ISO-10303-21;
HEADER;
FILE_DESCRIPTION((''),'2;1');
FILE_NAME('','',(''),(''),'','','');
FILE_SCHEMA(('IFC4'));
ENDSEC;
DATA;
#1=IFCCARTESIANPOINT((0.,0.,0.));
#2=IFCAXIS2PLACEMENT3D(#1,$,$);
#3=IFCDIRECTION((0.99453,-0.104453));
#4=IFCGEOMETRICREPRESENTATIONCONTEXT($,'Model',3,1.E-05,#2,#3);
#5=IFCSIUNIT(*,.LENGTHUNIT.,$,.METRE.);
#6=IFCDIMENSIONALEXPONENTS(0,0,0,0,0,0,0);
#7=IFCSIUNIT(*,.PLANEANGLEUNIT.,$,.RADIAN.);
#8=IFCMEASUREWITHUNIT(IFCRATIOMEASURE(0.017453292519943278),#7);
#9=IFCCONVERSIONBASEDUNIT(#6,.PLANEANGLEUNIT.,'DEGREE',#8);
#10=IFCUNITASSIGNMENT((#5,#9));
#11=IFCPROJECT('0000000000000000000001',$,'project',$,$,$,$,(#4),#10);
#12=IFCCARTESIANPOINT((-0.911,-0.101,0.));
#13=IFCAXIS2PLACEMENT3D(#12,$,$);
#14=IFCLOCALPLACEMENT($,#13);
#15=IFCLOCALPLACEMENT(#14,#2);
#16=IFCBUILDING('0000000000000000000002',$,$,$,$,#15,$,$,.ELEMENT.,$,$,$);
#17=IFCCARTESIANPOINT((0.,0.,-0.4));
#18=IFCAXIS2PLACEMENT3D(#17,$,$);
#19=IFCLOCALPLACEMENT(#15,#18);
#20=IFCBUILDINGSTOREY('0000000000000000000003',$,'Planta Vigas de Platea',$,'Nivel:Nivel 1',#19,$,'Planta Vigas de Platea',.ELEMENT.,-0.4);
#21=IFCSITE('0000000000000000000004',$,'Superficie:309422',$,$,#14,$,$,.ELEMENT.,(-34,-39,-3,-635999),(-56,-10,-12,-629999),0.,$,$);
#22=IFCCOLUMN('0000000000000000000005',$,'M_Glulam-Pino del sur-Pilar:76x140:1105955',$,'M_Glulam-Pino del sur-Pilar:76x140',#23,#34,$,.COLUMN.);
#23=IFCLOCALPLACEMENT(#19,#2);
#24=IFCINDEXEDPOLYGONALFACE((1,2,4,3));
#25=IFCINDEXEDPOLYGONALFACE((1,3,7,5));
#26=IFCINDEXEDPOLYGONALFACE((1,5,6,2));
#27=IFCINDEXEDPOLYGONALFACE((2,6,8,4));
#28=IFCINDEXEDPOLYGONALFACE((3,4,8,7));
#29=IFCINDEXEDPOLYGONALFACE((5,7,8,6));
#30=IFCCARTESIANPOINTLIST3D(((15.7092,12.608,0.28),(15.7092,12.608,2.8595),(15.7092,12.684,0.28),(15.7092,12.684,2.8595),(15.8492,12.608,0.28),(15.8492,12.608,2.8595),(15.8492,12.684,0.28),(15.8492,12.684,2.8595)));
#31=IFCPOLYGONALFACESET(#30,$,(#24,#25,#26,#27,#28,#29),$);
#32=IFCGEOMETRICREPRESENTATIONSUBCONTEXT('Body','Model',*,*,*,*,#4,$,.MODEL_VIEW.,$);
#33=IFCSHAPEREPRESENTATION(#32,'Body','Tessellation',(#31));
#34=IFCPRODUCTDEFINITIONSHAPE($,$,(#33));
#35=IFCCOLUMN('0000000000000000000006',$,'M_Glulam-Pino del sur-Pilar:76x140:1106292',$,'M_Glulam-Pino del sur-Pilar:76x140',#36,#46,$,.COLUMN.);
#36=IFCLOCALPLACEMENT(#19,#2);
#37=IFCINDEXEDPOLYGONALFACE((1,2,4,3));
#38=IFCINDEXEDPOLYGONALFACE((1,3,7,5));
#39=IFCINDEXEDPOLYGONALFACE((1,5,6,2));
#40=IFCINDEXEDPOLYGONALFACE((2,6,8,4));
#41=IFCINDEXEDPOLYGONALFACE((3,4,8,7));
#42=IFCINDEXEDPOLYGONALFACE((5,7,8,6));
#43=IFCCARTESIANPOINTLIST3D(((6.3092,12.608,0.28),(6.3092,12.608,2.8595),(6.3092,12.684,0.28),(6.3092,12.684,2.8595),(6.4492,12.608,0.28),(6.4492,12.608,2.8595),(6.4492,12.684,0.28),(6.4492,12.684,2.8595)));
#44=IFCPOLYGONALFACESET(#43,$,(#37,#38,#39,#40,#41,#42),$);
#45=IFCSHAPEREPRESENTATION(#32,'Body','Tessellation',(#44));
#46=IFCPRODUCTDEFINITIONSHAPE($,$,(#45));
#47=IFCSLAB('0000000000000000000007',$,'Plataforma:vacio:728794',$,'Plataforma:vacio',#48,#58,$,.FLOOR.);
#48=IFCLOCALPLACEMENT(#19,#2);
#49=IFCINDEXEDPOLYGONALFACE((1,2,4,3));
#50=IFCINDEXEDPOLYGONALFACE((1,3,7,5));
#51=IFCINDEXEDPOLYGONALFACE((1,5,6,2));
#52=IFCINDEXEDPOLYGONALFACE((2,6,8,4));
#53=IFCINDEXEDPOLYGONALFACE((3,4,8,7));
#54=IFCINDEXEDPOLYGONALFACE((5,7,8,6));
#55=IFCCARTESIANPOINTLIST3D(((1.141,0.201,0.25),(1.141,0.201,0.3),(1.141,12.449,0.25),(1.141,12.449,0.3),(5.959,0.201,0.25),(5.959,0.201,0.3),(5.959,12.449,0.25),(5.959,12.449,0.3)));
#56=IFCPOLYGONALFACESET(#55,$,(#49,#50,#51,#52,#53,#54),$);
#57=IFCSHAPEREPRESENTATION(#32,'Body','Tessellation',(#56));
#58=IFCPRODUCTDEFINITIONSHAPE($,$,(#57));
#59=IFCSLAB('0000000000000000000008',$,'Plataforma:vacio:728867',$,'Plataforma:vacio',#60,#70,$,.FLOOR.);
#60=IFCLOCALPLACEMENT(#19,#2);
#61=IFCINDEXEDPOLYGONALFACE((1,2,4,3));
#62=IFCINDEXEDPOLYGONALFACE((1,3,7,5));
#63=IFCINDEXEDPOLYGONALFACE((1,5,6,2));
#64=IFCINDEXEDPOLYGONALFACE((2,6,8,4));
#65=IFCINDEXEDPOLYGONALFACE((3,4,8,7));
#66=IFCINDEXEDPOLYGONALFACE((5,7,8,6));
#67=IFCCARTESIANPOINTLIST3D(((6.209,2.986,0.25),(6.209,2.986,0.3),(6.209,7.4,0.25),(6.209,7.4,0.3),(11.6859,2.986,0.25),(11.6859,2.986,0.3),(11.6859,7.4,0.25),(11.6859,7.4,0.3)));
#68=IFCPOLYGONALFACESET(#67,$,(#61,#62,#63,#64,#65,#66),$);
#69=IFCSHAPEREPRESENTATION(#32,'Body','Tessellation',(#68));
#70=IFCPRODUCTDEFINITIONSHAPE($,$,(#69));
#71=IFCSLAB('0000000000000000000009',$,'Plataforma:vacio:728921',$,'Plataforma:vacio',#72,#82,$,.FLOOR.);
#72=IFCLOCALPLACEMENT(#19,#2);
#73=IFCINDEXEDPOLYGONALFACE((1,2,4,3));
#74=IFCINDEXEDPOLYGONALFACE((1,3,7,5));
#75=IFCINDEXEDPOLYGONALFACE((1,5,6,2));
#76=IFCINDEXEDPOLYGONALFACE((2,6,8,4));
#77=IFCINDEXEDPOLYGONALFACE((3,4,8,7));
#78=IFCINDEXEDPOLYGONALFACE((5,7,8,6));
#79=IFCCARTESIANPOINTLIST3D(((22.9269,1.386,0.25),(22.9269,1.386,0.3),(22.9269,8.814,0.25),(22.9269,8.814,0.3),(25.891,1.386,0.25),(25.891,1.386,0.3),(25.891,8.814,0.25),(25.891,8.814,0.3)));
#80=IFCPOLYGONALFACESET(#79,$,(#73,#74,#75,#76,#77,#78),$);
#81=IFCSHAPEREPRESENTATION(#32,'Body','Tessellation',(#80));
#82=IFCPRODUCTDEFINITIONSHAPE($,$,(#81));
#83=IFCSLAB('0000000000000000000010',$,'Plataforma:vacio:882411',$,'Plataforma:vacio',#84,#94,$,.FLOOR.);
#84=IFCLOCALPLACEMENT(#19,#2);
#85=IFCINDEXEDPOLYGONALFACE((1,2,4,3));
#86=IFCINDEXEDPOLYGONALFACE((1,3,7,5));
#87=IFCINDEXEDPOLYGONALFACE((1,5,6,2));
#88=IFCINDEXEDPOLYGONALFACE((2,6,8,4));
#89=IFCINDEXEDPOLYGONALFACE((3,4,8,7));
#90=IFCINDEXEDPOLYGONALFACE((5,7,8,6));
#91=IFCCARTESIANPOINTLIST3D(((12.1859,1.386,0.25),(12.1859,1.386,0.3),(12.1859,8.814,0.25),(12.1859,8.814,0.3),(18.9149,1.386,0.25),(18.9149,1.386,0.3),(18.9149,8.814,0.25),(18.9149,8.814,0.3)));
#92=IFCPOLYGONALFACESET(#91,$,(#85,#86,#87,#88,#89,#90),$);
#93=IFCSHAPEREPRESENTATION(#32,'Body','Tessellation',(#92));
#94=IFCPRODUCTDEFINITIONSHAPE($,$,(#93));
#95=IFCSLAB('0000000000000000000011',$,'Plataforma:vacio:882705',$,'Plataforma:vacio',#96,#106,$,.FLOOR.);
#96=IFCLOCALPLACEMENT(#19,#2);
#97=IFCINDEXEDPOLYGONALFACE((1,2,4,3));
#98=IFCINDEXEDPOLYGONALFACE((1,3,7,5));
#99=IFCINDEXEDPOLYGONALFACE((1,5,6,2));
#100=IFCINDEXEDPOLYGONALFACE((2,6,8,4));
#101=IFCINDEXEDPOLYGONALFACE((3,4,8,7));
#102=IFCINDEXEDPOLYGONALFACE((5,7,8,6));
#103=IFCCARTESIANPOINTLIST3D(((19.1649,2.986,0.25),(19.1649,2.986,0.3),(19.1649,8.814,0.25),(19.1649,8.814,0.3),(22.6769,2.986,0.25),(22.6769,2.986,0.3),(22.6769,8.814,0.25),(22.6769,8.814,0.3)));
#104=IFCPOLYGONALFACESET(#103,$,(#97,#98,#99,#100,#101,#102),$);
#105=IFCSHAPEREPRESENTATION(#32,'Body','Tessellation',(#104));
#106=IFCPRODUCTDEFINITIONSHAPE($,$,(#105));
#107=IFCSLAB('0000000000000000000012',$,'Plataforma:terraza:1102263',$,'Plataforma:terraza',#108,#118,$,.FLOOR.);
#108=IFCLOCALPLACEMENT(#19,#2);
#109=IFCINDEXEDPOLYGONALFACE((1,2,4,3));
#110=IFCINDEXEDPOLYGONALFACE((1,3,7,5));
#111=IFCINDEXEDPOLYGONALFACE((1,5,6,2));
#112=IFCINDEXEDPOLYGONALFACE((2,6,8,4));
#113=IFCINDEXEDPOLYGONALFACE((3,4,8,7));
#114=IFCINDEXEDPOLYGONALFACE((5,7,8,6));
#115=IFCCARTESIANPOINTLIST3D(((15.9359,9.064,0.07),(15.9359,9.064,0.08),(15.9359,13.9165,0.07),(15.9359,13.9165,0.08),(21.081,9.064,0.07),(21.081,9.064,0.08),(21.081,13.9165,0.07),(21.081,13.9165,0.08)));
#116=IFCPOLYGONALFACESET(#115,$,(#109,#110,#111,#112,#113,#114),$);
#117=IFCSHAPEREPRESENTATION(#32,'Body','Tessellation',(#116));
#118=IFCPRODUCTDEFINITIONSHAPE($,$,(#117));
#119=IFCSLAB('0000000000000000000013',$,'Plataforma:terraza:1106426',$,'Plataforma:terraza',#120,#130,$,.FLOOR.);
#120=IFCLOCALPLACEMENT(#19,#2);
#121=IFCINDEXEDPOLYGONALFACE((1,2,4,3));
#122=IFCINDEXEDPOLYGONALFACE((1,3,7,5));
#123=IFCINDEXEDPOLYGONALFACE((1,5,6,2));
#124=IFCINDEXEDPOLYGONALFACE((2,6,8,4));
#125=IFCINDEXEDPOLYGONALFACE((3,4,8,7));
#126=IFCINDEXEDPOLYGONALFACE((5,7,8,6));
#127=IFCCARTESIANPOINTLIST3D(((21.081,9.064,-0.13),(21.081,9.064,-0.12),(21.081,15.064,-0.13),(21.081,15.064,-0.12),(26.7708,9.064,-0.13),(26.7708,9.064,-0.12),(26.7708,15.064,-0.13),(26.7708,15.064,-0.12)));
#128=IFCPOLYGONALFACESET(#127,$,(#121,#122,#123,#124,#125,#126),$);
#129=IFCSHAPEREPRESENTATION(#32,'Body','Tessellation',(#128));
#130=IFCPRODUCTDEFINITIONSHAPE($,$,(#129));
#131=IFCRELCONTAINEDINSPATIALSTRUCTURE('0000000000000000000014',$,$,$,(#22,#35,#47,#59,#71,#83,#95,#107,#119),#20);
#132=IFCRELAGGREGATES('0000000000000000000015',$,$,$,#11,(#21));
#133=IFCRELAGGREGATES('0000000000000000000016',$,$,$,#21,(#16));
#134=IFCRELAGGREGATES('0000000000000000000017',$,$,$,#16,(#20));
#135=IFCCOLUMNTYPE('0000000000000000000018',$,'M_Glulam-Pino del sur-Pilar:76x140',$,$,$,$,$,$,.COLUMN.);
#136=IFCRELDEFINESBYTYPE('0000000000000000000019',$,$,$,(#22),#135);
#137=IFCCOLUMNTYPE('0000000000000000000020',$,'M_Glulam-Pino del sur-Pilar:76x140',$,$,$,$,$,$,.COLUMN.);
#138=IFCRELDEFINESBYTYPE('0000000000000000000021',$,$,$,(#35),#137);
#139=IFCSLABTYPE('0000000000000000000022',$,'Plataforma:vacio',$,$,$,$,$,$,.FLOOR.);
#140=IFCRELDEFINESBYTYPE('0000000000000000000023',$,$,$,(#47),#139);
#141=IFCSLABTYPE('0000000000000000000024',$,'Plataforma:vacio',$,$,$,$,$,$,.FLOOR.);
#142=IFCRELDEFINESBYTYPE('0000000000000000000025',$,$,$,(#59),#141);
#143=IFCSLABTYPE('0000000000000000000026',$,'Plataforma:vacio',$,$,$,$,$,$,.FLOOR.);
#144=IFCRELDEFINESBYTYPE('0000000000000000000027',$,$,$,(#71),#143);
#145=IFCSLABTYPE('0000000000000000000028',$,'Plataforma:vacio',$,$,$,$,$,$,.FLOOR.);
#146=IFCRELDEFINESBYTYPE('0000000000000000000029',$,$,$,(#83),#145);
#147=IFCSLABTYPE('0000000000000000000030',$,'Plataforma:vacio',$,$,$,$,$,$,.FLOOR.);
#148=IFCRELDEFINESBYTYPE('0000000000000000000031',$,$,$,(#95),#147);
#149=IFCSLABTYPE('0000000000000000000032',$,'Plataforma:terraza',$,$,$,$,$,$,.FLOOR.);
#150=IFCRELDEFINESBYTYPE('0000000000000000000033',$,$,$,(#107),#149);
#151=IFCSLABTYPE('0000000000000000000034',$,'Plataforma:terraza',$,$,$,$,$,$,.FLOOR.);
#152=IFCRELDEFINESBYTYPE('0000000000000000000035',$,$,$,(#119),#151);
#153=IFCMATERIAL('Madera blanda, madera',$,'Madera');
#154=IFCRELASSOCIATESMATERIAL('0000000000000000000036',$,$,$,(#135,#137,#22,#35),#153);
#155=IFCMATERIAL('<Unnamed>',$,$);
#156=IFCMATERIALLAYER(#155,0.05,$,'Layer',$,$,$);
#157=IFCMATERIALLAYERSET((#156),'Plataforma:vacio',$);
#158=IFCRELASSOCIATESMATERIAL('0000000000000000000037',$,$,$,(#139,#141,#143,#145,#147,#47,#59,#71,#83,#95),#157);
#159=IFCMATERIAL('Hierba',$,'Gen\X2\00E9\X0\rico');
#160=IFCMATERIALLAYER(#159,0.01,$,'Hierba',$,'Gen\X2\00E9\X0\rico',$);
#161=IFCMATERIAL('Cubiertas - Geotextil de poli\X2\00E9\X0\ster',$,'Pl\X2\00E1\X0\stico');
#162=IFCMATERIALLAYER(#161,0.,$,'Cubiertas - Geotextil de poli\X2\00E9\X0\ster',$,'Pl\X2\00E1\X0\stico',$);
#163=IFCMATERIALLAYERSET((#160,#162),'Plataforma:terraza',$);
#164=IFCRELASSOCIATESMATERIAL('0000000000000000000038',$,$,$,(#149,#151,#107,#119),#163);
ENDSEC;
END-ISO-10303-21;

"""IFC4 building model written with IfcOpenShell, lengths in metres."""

from ifc_helpers import new_model, entity, si_unit, converted_unit, direction, frame, frame_2d, origin, origin_2d_with_axis, place, context, subcontext, project, spatial, polyline, segment, composite_curve, rectangle, outline, extrude, source, transform, mapped, material, layer, layer_set, layer_usage, material_profile, profile_set, profile_usage, type_object, type_shapes, element, save


model = new_model("IFC4")

# Units and contexts
model_context = context("Model", 3, precision=1e-05, world=origin(), true_north=direction((0.99453, -0.104453)))
body_context = subcontext(model_context, "Body", "Model", "MODEL_VIEW")
ifc_project = project(units=[si_unit("LENGTHUNIT", "METRE"), converted_unit("PLANEANGLEUNIT", "DEGREE", entity("IfcRatioMeasure", 0.017453292519943278), si_unit("PLANEANGLEUNIT", "RADIAN"), dimensions=[0, 0, 0, 0, 0, 0, 0])], contexts=[model_context])

# Site, building, storey
site_placement = place(None, frame((-0.911, -0.101, 0.0)))
site = spatial("IfcSite", under=ifc_project, at=site_placement, Name="Superficie:309422", CompositionType="ELEMENT", RefLatitude=(-34, -39, -3, -635999), RefLongitude=(-56, -10, -12, -629999), RefElevation=0.0)
building_placement = place(site_placement, origin())
building = spatial("IfcBuilding", under=site, at=building_placement, CompositionType="ELEMENT")
storey_placement = place(building_placement, frame((0.0, 0.0, -0.4)))
storey = spatial("IfcBuildingStorey", under=building, at=storey_placement, Name="Planta Vigas de Platea", ObjectType="Nivel:Nivel 1", LongName="Planta Vigas de Platea", CompositionType="ELEMENT", Elevation=-0.4)

# Columns
ifc_material_1 = material(Name="Madera blanda, madera", Category="Madera")
ifc_material_profile_1 = material_profile(ifc_material_1, outline(composite_curve([segment(polyline([(0.038, 0.07, 0.0), (0.038, -0.07, 0.0)]), True, "CONTINUOUS"), segment(polyline([(0.038, -0.07, 0.0), (-0.038, -0.07, 0.0)]), True, "CONTINUOUS"), segment(polyline([(-0.038, -0.07, 0.0), (-0.038, 0.07, 0.0)]), True, "CONTINUOUS"), segment(polyline([(-0.038, 0.07, 0.0), (0.038, 0.07, 0.0)]), True, "CONTINUOUS")], self_intersect=False), kind="CURVE"), Name="76x140")
ifc_material_profile_2 = material_profile(ifc_material_1, outline(composite_curve([segment(polyline([(0.038, 0.07, 0.0), (0.038, -0.07, 0.0)]), True, "CONTINUOUS"), segment(polyline([(0.038, -0.07, 0.0), (-0.038, -0.07, 0.0)]), True, "CONTINUOUS"), segment(polyline([(-0.038, -0.07, 0.0), (-0.038, 0.07, 0.0)]), True, "CONTINUOUS"), segment(polyline([(-0.038, 0.07, 0.0), (0.038, 0.07, 0.0)]), True, "CONTINUOUS")], self_intersect=False), kind="CURVE"), Name="76x140")
ifc_profile_set = profile_set([ifc_material_profile_1, ifc_material_profile_2], Name="76x140")
ifc_profile_usage_1 = profile_usage(ifc_profile_set)
column_type_1 = type_object("IfcColumnType", Name="M_Glulam-Pino del sur-Pilar:76x140", PredefinedType="COLUMN", material=ifc_profile_set)
shared_shape_1 = source(origin(), body_context, "Body", "SweptSolid", [
    extrude(rectangle(XDim=0.076, YDim=0.14, at=origin_2d_with_axis()), frame((15.7792, 12.646, -0.12), z_axis=(0.0, 0.0, 1.0), x_axis=(0.0, -1.0, 0.0)), (0.0, 0.0, 1.0), 2.5795),
])
type_shapes(column_type_1, [shared_shape_1])
column_1_placement = place(storey_placement, frame((0.0, 0.0, 0.4)))
element("IfcColumn", 1, at=column_1_placement, inside=storey, type_object=column_type_1, material=ifc_profile_usage_1, Name="M_Glulam-Pino del sur-Pilar:76x140:1105955", ObjectType="M_Glulam-Pino del sur-Pilar:76x140", PredefinedType="COLUMN", context=body_context, shape_type="MappedRepresentation", body=[
    mapped(shared_shape_1, transform((0.0, 0.0, 0.0), scale=1.0)),
])
ifc_profile_usage_2 = profile_usage(ifc_profile_set)
column_type_2 = type_object("IfcColumnType", Name="M_Glulam-Pino del sur-Pilar:76x140", PredefinedType="COLUMN", material=ifc_profile_set)
shared_shape_2 = source(origin(), body_context, "Body", "SweptSolid", [
    extrude(rectangle(XDim=0.076, YDim=0.14, at=origin_2d_with_axis()), frame((6.3792, 12.646, -0.12), z_axis=(0.0, 0.0, 1.0), x_axis=(0.0, -1.0, 0.0)), (0.0, 0.0, 1.0), 2.5795),
])
type_shapes(column_type_2, [shared_shape_2])
column_2_placement = place(storey_placement, frame((0.0, 0.0, 0.4)))
element("IfcColumn", 2, at=column_2_placement, inside=storey, type_object=column_type_2, material=ifc_profile_usage_2, Name="M_Glulam-Pino del sur-Pilar:76x140:1106292", ObjectType="M_Glulam-Pino del sur-Pilar:76x140", PredefinedType="COLUMN", context=body_context, shape_type="MappedRepresentation", body=[
    mapped(shared_shape_2, transform((0.0, 0.0, 0.0), scale=1.0)),
])

# Slabs
ifc_material_2 = material(Name="<Unnamed>")
ifc_layer_1 = layer(ifc_material_2, 0.05, Name="Layer")
ifc_layer_set_1 = layer_set([ifc_layer_1], Name="Plataforma:vacio")
ifc_layer_usage_1 = layer_usage(ifc_layer_set_1, "AXIS3", "POSITIVE", 0.0)
slab_type_1 = type_object("IfcSlabType", Name="Plataforma:vacio", PredefinedType="FLOOR", material=ifc_layer_set_1)
slab_1_placement = place(storey_placement, origin())
element("IfcSlab", 3, at=slab_1_placement, inside=storey, type_object=slab_type_1, material=ifc_layer_usage_1, Name="Plataforma:vacio:728794", ObjectType="Plataforma:vacio", PredefinedType="FLOOR", context=body_context, shape_type="SweptSolid", body=[
    extrude(rectangle(XDim=4.818, YDim=12.248, at=origin_2d_with_axis()), frame((3.55, 6.325, 0.25), z_axis=(0.0, 0.0, 1.0), x_axis=(-1.0, 0.0, 0.0)), (0.0, 0.0, 1.0), 0.05),
])
ifc_layer_usage_2 = layer_usage(ifc_layer_set_1, "AXIS3", "POSITIVE", 0.0)
slab_type_2 = type_object("IfcSlabType", Name="Plataforma:vacio", PredefinedType="FLOOR", material=ifc_layer_set_1)
slab_2_placement = place(storey_placement, origin())
element("IfcSlab", 4, at=slab_2_placement, inside=storey, type_object=slab_type_2, material=ifc_layer_usage_2, Name="Plataforma:vacio:728867", ObjectType="Plataforma:vacio", PredefinedType="FLOOR", context=body_context, shape_type="SweptSolid", body=[
    extrude(rectangle(XDim=5.4769, YDim=4.414, at=frame_2d((0.0, 0.0), x_axis=(1.0, 0.0))), frame((8.9475, 5.193, 0.25), z_axis=(0.0, 0.0, 1.0), x_axis=(-1.0, 0.0, 0.0)), (0.0, 0.0, 1.0), 0.05),
])
ifc_layer_usage_3 = layer_usage(ifc_layer_set_1, "AXIS3", "POSITIVE", 0.0)
slab_type_3 = type_object("IfcSlabType", Name="Plataforma:vacio", PredefinedType="FLOOR", material=ifc_layer_set_1)
slab_3_placement = place(storey_placement, origin())
element("IfcSlab", 5, at=slab_3_placement, inside=storey, type_object=slab_type_3, material=ifc_layer_usage_3, Name="Plataforma:vacio:728921", ObjectType="Plataforma:vacio", PredefinedType="FLOOR", context=body_context, shape_type="SweptSolid", body=[
    extrude(rectangle(XDim=2.964, YDim=7.428, at=frame_2d((0.0, 0.0), x_axis=(1.0, 0.0))), frame((24.409, 5.1, 0.25), z_axis=(0.0, 0.0, 1.0), x_axis=(-1.0, 0.0, 0.0)), (0.0, 0.0, 1.0), 0.05),
])
ifc_layer_usage_4 = layer_usage(ifc_layer_set_1, "AXIS3", "POSITIVE", 0.0)
slab_type_4 = type_object("IfcSlabType", Name="Plataforma:vacio", PredefinedType="FLOOR", material=ifc_layer_set_1)
slab_4_placement = place(storey_placement, origin())
element("IfcSlab", 6, at=slab_4_placement, inside=storey, type_object=slab_type_4, material=ifc_layer_usage_4, Name="Plataforma:vacio:882411", ObjectType="Plataforma:vacio", PredefinedType="FLOOR", context=body_context, shape_type="SweptSolid", body=[
    extrude(rectangle(XDim=6.729, YDim=7.428, at=frame_2d((0.0, 0.0), x_axis=(1.0, 0.0))), frame((15.5504, 5.1, 0.25), z_axis=(0.0, 0.0, 1.0), x_axis=(-1.0, 0.0, 0.0)), (0.0, 0.0, 1.0), 0.05),
])
ifc_layer_usage_5 = layer_usage(ifc_layer_set_1, "AXIS3", "POSITIVE", 0.0)
slab_type_5 = type_object("IfcSlabType", Name="Plataforma:vacio", PredefinedType="FLOOR", material=ifc_layer_set_1)
slab_5_placement = place(storey_placement, origin())
element("IfcSlab", 7, at=slab_5_placement, inside=storey, type_object=slab_type_5, material=ifc_layer_usage_5, Name="Plataforma:vacio:882705", ObjectType="Plataforma:vacio", PredefinedType="FLOOR", context=body_context, shape_type="SweptSolid", body=[
    extrude(rectangle(XDim=3.512, YDim=5.828, at=frame_2d((0.0, 0.0), x_axis=(1.0, 0.0))), frame((20.9209, 5.9, 0.25), z_axis=(0.0, 0.0, 1.0), x_axis=(-1.0, 0.0, 0.0)), (0.0, 0.0, 1.0), 0.05),
])
ifc_material_3 = material(Name="Hierba", Category="Genérico")
ifc_layer_2 = layer(ifc_material_3, 0.01, Name="Hierba", Category="Genérico")
ifc_material_4 = material(Name="Cubiertas - Geotextil de poliéster", Category="Plástico")
ifc_layer_3 = layer(ifc_material_4, 0.0, Name="Cubiertas - Geotextil de poliéster", Category="Plástico")
ifc_layer_set_2 = layer_set([ifc_layer_2, ifc_layer_3], Name="Plataforma:terraza")
ifc_layer_usage_6 = layer_usage(ifc_layer_set_2, "AXIS3", "POSITIVE", 0.0)
slab_type_6 = type_object("IfcSlabType", Name="Plataforma:terraza", PredefinedType="FLOOR", material=ifc_layer_set_2)
slab_6_placement = place(storey_placement, origin())
element("IfcSlab", 8, at=slab_6_placement, inside=storey, type_object=slab_type_6, material=ifc_layer_usage_6, Name="Plataforma:terraza:1102263", ObjectType="Plataforma:terraza", PredefinedType="FLOOR", context=body_context, shape_type="SweptSolid", body=[
    extrude(rectangle(XDim=4.8525, YDim=5.145, at=frame_2d((0.0, 0.0), x_axis=(1.0, 0.0))), frame((18.5084, 11.4903, 0.07), z_axis=(0.0, 0.0, 1.0), x_axis=(0.0, 1.0, 0.0)), (0.0, 0.0, 1.0), 0.01),
])
ifc_layer_usage_7 = layer_usage(ifc_layer_set_2, "AXIS3", "POSITIVE", 0.0)
slab_type_7 = type_object("IfcSlabType", Name="Plataforma:terraza", PredefinedType="FLOOR", material=ifc_layer_set_2)
slab_7_placement = place(storey_placement, origin())
element("IfcSlab", 9, at=slab_7_placement, inside=storey, type_object=slab_type_7, material=ifc_layer_usage_7, Name="Plataforma:terraza:1106426", ObjectType="Plataforma:terraza", PredefinedType="FLOOR", context=body_context, shape_type="SweptSolid", body=[
    extrude(rectangle(XDim=6.0, YDim=5.6899, at=frame_2d((0.0, 0.0), x_axis=(1.0, 0.0))), frame((23.9259, 12.064, -0.13), z_axis=(0.0, 0.0, 1.0), x_axis=(0.0, 1.0, 0.0)), (0.0, 0.0, 1.0), 0.01),
])

save(model, "model.ifc")
